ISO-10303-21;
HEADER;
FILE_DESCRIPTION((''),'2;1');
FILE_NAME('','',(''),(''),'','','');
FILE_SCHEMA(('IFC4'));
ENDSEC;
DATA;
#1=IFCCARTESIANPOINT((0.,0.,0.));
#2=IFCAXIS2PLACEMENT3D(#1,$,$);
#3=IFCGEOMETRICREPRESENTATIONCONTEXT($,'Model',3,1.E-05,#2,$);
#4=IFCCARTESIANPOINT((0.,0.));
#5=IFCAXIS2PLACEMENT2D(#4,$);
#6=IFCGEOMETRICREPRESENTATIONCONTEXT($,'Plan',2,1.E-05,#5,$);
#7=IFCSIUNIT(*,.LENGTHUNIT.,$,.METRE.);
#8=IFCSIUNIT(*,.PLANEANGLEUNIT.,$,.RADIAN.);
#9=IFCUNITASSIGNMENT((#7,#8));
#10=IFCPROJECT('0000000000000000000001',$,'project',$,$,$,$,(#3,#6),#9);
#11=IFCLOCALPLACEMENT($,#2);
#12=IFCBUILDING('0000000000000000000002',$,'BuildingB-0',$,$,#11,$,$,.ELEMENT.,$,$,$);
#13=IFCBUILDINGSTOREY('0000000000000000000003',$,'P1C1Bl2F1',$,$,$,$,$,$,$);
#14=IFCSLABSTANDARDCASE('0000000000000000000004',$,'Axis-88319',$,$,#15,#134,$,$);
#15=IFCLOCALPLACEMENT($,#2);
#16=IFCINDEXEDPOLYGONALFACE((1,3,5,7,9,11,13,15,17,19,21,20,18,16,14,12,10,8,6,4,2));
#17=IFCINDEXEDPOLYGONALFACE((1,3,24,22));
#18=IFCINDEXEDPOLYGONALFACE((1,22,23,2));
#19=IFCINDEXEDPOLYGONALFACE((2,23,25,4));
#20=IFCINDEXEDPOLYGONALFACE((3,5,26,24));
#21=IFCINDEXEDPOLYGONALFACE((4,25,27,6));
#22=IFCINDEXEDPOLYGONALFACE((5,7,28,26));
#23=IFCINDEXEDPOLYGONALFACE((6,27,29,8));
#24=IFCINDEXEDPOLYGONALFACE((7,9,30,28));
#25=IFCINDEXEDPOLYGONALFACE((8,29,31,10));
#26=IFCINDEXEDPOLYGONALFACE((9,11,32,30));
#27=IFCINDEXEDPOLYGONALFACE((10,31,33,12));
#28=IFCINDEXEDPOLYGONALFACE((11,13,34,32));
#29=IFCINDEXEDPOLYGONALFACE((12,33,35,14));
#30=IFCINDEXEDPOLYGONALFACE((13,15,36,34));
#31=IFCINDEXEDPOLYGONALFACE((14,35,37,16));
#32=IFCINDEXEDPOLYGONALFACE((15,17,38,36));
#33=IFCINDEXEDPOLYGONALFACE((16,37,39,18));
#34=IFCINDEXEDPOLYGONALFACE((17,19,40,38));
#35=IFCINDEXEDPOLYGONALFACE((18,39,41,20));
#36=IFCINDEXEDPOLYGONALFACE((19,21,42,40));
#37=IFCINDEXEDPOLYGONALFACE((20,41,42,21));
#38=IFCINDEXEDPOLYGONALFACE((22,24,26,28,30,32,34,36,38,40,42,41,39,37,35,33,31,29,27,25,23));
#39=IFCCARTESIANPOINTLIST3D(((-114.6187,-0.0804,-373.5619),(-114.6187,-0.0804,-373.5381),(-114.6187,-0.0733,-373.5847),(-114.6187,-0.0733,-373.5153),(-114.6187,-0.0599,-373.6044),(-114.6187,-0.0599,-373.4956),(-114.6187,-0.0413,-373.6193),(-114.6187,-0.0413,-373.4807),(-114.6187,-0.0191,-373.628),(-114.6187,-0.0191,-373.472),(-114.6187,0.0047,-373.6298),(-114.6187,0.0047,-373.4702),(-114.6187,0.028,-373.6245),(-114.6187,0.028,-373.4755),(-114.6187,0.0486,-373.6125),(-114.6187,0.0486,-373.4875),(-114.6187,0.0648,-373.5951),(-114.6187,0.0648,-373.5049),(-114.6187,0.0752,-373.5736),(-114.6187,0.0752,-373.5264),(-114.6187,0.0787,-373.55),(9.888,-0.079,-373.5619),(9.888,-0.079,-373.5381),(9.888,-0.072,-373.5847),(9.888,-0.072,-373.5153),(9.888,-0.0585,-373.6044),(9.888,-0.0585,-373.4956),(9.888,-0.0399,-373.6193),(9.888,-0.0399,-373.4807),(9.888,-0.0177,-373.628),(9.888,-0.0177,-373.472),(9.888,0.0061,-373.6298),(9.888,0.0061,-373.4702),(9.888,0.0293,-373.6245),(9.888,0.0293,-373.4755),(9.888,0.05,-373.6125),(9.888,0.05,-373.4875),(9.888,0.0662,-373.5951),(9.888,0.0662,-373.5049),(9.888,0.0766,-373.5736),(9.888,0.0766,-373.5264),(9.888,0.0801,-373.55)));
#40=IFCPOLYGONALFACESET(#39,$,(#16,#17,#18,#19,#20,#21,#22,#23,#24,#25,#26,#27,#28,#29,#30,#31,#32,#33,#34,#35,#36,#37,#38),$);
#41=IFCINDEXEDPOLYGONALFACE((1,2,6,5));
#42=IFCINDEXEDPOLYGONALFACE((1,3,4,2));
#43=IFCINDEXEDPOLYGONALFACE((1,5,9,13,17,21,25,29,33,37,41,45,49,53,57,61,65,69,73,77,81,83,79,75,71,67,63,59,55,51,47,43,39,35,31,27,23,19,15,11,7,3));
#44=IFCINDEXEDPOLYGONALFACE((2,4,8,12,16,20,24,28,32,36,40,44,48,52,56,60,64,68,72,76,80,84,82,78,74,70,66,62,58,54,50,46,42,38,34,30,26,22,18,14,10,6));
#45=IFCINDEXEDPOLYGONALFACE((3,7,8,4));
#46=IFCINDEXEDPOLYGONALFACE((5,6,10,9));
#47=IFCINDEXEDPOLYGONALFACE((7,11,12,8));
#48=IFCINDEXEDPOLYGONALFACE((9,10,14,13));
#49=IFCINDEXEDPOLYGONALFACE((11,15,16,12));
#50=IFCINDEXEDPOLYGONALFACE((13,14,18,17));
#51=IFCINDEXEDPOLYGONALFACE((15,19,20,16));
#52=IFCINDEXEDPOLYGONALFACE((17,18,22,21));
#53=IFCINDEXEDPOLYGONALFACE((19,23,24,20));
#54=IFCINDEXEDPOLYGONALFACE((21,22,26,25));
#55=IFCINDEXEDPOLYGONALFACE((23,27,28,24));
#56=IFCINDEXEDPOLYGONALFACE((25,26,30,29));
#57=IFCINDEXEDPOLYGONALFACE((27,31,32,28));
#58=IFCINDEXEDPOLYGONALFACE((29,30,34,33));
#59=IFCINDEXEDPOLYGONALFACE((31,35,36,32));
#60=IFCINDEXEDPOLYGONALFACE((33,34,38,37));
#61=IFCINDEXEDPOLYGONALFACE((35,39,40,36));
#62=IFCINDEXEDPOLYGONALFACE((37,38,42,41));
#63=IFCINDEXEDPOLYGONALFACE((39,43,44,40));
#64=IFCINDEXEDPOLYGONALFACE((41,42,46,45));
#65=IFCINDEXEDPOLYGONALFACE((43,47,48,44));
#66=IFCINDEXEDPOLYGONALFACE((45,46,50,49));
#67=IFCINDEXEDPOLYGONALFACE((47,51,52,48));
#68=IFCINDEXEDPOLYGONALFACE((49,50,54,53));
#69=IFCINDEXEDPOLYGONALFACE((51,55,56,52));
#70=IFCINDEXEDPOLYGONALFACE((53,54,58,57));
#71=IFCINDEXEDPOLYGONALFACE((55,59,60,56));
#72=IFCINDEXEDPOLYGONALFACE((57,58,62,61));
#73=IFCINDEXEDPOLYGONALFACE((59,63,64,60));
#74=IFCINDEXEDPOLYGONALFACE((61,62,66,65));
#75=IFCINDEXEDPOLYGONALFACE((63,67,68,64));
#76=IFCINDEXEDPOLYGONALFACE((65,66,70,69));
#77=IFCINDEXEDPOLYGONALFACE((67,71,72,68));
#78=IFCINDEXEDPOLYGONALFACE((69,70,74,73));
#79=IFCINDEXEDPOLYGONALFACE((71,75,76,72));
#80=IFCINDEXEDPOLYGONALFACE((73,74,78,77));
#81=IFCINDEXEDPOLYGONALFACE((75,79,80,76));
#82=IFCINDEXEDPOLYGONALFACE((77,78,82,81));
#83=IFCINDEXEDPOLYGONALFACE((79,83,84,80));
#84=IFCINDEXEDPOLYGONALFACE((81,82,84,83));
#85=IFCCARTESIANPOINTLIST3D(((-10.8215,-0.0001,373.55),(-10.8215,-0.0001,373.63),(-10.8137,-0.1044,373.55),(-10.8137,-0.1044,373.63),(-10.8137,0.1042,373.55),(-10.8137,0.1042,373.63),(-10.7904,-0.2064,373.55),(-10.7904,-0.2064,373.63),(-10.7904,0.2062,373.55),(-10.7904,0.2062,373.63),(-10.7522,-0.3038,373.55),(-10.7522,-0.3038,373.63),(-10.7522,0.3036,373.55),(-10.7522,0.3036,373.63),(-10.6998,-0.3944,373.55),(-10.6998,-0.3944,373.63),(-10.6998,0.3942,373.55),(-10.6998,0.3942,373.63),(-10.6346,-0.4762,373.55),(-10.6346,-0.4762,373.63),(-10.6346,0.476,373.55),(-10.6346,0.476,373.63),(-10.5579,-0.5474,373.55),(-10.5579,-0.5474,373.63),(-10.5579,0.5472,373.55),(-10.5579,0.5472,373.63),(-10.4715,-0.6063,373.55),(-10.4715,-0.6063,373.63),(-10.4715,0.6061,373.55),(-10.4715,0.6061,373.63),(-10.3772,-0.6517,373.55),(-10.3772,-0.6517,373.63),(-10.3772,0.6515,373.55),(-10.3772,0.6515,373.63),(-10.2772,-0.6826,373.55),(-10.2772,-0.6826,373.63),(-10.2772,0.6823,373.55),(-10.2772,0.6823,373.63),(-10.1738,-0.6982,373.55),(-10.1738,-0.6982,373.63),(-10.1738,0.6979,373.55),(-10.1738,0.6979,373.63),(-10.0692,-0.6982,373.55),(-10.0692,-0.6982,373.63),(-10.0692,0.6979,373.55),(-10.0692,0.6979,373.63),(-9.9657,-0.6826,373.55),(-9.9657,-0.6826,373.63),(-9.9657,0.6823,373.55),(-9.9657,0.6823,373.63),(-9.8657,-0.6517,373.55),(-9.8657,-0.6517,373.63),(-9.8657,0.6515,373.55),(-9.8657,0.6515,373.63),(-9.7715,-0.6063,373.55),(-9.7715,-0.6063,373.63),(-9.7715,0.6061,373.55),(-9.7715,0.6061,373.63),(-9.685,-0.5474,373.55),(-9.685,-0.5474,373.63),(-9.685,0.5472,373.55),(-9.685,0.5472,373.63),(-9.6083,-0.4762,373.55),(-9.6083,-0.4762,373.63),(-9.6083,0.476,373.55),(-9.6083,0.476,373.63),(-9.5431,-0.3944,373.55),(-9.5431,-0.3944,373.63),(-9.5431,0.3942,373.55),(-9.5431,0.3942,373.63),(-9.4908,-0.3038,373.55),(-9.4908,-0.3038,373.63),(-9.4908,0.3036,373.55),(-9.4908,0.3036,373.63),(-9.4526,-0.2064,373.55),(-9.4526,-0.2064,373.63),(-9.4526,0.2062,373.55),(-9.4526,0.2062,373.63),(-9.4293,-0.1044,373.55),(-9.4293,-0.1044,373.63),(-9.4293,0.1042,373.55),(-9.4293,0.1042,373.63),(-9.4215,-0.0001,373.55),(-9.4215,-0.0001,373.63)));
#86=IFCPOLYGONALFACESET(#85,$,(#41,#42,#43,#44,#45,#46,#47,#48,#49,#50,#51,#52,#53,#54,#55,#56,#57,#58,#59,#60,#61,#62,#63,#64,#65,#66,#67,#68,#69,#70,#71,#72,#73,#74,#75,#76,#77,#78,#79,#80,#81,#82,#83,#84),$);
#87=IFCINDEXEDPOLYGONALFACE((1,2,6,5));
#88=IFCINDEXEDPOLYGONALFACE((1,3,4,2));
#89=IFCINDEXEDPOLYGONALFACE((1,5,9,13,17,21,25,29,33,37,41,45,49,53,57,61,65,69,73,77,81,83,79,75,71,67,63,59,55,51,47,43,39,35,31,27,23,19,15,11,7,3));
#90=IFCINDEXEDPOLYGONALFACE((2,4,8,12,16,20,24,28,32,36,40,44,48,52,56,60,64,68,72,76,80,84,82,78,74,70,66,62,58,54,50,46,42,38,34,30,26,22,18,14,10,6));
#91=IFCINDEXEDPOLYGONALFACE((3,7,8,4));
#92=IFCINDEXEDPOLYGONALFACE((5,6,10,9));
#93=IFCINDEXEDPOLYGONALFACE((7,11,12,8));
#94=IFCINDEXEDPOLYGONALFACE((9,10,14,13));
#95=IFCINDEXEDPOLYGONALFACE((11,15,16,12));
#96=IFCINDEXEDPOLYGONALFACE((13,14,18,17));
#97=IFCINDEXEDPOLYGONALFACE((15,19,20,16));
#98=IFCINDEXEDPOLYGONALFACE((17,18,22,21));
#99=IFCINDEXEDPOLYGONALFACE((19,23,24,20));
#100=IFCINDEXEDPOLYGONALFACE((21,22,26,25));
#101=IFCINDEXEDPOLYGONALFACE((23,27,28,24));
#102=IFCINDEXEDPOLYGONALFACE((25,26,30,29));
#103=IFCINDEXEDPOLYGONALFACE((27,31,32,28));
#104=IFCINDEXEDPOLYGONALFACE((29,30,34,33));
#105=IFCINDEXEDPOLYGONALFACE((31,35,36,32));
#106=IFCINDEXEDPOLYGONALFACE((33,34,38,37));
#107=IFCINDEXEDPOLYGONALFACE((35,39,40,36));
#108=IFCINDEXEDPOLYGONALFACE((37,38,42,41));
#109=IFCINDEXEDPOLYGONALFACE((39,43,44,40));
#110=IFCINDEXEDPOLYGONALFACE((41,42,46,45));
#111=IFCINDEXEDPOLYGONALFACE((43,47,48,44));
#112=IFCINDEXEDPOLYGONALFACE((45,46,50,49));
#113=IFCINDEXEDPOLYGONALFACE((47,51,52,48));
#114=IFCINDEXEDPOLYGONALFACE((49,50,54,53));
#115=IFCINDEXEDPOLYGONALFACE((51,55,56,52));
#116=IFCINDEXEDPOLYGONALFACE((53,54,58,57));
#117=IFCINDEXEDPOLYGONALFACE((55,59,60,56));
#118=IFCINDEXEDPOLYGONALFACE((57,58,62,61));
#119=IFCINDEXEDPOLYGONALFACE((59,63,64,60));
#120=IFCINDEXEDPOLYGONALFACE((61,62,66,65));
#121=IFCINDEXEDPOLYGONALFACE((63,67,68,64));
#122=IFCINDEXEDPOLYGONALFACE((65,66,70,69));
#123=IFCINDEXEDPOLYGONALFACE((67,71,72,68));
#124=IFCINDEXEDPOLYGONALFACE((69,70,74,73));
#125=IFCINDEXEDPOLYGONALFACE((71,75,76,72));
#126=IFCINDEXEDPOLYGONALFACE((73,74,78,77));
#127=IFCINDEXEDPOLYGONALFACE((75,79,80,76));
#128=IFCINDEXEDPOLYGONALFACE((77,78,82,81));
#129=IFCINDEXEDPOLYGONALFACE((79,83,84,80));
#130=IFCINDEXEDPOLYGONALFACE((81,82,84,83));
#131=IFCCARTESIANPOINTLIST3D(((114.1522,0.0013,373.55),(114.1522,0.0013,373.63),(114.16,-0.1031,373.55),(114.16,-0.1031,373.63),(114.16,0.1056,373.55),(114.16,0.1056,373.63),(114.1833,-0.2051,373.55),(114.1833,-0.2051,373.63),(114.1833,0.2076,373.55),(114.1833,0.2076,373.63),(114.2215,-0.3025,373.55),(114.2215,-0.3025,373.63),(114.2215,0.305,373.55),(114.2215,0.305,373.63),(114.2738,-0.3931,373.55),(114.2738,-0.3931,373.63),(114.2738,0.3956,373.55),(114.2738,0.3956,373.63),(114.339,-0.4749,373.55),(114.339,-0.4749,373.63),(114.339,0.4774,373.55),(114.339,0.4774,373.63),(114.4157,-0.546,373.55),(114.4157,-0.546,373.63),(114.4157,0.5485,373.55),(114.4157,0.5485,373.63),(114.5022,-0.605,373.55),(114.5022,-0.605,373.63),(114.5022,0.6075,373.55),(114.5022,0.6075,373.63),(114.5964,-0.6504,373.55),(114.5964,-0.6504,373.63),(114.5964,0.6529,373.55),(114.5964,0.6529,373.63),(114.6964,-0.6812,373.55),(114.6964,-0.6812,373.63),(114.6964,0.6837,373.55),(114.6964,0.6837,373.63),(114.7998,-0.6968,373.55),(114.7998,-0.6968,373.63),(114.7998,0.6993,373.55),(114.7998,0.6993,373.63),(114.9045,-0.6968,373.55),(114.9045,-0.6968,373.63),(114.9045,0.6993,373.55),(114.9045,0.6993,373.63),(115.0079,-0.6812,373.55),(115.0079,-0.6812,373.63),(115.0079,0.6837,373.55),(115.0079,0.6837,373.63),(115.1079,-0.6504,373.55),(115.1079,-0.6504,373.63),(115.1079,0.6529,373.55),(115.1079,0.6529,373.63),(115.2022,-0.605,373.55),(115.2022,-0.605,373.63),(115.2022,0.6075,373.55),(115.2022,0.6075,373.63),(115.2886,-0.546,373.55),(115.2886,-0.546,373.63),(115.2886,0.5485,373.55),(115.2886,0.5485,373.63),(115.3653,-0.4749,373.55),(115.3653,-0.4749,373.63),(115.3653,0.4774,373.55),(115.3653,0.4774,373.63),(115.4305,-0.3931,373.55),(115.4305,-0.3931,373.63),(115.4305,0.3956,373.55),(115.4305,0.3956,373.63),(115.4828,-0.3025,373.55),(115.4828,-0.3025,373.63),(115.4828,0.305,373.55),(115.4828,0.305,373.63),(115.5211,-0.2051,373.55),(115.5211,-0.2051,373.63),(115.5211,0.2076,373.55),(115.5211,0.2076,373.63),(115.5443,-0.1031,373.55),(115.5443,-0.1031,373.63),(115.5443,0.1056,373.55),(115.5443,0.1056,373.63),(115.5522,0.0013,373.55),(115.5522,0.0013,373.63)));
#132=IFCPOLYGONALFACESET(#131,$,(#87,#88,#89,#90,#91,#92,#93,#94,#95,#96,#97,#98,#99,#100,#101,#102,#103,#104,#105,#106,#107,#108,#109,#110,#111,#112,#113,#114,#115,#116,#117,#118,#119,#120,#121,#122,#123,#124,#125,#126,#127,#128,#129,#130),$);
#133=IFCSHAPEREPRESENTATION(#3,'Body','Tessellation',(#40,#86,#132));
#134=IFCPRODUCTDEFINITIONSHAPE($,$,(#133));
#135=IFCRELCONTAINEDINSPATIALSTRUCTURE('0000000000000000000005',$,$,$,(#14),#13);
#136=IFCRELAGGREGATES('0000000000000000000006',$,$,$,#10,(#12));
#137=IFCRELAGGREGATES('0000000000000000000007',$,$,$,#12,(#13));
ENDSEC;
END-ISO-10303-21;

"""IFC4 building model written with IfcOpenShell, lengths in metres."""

from ifc_helpers import new_model, entity, si_unit, frame, origin, origin_2d, place, context, project, spatial, circle, extrude, element, save


model = new_model("IFC4")

# Units and contexts
model_context = context("Model", 3, precision=1e-05, world=origin())
plan_context = context("Plan", 2, precision=1e-05, world=origin_2d())
ifc_project = project(units=[si_unit("LENGTHUNIT", "METRE"), si_unit("PLANEANGLEUNIT", "RADIAN")], contexts=[model_context, plan_context])

# Building, storey
building_placement = place(None, origin())
building = spatial("IfcBuilding", under=ifc_project, at=building_placement, Name="BuildingB-0", CompositionType="ELEMENT")
storey = spatial("IfcBuildingStorey", under=building, Name="P1C1Bl2F1")

# Slab
element("IfcSlabStandardCase", 1, inside=storey, Name="Axis-88319", context=model_context, shape_type="AdvancedSweptSolid", body=[
    entity("IfcSurfaceCurveSweptAreaSolid", entity("IfcCircleProfileDef", "AREA", None, None, 0.08), None, entity("IfcPolyline", [entity("IfcCartesianPoint", [-9.888, -0.0001, 373.55]), entity("IfcCartesianPoint", [114.6187, 0.0013, 373.55])]), None, None, entity("IfcPlane", entity("IfcAxis2Placement3D", entity("IfcCartesianPoint", [-9.888, -0.0001, 373.55]), entity("IfcDirection", [0.0, 0.0, 1.0]), entity("IfcDirection", [1.0, 0.0, 0.0])))),
    extrude(circle(Radius=0.7), frame((-10.1215, -0.0001, 373.55)), (0.0, 0.0, 1.0), 0.08),
    extrude(circle(Radius=0.7), frame((114.8522, 0.0013, 373.55)), (0.0, 0.0, 1.0), 0.08),
])

save(model, "model.ifc")
